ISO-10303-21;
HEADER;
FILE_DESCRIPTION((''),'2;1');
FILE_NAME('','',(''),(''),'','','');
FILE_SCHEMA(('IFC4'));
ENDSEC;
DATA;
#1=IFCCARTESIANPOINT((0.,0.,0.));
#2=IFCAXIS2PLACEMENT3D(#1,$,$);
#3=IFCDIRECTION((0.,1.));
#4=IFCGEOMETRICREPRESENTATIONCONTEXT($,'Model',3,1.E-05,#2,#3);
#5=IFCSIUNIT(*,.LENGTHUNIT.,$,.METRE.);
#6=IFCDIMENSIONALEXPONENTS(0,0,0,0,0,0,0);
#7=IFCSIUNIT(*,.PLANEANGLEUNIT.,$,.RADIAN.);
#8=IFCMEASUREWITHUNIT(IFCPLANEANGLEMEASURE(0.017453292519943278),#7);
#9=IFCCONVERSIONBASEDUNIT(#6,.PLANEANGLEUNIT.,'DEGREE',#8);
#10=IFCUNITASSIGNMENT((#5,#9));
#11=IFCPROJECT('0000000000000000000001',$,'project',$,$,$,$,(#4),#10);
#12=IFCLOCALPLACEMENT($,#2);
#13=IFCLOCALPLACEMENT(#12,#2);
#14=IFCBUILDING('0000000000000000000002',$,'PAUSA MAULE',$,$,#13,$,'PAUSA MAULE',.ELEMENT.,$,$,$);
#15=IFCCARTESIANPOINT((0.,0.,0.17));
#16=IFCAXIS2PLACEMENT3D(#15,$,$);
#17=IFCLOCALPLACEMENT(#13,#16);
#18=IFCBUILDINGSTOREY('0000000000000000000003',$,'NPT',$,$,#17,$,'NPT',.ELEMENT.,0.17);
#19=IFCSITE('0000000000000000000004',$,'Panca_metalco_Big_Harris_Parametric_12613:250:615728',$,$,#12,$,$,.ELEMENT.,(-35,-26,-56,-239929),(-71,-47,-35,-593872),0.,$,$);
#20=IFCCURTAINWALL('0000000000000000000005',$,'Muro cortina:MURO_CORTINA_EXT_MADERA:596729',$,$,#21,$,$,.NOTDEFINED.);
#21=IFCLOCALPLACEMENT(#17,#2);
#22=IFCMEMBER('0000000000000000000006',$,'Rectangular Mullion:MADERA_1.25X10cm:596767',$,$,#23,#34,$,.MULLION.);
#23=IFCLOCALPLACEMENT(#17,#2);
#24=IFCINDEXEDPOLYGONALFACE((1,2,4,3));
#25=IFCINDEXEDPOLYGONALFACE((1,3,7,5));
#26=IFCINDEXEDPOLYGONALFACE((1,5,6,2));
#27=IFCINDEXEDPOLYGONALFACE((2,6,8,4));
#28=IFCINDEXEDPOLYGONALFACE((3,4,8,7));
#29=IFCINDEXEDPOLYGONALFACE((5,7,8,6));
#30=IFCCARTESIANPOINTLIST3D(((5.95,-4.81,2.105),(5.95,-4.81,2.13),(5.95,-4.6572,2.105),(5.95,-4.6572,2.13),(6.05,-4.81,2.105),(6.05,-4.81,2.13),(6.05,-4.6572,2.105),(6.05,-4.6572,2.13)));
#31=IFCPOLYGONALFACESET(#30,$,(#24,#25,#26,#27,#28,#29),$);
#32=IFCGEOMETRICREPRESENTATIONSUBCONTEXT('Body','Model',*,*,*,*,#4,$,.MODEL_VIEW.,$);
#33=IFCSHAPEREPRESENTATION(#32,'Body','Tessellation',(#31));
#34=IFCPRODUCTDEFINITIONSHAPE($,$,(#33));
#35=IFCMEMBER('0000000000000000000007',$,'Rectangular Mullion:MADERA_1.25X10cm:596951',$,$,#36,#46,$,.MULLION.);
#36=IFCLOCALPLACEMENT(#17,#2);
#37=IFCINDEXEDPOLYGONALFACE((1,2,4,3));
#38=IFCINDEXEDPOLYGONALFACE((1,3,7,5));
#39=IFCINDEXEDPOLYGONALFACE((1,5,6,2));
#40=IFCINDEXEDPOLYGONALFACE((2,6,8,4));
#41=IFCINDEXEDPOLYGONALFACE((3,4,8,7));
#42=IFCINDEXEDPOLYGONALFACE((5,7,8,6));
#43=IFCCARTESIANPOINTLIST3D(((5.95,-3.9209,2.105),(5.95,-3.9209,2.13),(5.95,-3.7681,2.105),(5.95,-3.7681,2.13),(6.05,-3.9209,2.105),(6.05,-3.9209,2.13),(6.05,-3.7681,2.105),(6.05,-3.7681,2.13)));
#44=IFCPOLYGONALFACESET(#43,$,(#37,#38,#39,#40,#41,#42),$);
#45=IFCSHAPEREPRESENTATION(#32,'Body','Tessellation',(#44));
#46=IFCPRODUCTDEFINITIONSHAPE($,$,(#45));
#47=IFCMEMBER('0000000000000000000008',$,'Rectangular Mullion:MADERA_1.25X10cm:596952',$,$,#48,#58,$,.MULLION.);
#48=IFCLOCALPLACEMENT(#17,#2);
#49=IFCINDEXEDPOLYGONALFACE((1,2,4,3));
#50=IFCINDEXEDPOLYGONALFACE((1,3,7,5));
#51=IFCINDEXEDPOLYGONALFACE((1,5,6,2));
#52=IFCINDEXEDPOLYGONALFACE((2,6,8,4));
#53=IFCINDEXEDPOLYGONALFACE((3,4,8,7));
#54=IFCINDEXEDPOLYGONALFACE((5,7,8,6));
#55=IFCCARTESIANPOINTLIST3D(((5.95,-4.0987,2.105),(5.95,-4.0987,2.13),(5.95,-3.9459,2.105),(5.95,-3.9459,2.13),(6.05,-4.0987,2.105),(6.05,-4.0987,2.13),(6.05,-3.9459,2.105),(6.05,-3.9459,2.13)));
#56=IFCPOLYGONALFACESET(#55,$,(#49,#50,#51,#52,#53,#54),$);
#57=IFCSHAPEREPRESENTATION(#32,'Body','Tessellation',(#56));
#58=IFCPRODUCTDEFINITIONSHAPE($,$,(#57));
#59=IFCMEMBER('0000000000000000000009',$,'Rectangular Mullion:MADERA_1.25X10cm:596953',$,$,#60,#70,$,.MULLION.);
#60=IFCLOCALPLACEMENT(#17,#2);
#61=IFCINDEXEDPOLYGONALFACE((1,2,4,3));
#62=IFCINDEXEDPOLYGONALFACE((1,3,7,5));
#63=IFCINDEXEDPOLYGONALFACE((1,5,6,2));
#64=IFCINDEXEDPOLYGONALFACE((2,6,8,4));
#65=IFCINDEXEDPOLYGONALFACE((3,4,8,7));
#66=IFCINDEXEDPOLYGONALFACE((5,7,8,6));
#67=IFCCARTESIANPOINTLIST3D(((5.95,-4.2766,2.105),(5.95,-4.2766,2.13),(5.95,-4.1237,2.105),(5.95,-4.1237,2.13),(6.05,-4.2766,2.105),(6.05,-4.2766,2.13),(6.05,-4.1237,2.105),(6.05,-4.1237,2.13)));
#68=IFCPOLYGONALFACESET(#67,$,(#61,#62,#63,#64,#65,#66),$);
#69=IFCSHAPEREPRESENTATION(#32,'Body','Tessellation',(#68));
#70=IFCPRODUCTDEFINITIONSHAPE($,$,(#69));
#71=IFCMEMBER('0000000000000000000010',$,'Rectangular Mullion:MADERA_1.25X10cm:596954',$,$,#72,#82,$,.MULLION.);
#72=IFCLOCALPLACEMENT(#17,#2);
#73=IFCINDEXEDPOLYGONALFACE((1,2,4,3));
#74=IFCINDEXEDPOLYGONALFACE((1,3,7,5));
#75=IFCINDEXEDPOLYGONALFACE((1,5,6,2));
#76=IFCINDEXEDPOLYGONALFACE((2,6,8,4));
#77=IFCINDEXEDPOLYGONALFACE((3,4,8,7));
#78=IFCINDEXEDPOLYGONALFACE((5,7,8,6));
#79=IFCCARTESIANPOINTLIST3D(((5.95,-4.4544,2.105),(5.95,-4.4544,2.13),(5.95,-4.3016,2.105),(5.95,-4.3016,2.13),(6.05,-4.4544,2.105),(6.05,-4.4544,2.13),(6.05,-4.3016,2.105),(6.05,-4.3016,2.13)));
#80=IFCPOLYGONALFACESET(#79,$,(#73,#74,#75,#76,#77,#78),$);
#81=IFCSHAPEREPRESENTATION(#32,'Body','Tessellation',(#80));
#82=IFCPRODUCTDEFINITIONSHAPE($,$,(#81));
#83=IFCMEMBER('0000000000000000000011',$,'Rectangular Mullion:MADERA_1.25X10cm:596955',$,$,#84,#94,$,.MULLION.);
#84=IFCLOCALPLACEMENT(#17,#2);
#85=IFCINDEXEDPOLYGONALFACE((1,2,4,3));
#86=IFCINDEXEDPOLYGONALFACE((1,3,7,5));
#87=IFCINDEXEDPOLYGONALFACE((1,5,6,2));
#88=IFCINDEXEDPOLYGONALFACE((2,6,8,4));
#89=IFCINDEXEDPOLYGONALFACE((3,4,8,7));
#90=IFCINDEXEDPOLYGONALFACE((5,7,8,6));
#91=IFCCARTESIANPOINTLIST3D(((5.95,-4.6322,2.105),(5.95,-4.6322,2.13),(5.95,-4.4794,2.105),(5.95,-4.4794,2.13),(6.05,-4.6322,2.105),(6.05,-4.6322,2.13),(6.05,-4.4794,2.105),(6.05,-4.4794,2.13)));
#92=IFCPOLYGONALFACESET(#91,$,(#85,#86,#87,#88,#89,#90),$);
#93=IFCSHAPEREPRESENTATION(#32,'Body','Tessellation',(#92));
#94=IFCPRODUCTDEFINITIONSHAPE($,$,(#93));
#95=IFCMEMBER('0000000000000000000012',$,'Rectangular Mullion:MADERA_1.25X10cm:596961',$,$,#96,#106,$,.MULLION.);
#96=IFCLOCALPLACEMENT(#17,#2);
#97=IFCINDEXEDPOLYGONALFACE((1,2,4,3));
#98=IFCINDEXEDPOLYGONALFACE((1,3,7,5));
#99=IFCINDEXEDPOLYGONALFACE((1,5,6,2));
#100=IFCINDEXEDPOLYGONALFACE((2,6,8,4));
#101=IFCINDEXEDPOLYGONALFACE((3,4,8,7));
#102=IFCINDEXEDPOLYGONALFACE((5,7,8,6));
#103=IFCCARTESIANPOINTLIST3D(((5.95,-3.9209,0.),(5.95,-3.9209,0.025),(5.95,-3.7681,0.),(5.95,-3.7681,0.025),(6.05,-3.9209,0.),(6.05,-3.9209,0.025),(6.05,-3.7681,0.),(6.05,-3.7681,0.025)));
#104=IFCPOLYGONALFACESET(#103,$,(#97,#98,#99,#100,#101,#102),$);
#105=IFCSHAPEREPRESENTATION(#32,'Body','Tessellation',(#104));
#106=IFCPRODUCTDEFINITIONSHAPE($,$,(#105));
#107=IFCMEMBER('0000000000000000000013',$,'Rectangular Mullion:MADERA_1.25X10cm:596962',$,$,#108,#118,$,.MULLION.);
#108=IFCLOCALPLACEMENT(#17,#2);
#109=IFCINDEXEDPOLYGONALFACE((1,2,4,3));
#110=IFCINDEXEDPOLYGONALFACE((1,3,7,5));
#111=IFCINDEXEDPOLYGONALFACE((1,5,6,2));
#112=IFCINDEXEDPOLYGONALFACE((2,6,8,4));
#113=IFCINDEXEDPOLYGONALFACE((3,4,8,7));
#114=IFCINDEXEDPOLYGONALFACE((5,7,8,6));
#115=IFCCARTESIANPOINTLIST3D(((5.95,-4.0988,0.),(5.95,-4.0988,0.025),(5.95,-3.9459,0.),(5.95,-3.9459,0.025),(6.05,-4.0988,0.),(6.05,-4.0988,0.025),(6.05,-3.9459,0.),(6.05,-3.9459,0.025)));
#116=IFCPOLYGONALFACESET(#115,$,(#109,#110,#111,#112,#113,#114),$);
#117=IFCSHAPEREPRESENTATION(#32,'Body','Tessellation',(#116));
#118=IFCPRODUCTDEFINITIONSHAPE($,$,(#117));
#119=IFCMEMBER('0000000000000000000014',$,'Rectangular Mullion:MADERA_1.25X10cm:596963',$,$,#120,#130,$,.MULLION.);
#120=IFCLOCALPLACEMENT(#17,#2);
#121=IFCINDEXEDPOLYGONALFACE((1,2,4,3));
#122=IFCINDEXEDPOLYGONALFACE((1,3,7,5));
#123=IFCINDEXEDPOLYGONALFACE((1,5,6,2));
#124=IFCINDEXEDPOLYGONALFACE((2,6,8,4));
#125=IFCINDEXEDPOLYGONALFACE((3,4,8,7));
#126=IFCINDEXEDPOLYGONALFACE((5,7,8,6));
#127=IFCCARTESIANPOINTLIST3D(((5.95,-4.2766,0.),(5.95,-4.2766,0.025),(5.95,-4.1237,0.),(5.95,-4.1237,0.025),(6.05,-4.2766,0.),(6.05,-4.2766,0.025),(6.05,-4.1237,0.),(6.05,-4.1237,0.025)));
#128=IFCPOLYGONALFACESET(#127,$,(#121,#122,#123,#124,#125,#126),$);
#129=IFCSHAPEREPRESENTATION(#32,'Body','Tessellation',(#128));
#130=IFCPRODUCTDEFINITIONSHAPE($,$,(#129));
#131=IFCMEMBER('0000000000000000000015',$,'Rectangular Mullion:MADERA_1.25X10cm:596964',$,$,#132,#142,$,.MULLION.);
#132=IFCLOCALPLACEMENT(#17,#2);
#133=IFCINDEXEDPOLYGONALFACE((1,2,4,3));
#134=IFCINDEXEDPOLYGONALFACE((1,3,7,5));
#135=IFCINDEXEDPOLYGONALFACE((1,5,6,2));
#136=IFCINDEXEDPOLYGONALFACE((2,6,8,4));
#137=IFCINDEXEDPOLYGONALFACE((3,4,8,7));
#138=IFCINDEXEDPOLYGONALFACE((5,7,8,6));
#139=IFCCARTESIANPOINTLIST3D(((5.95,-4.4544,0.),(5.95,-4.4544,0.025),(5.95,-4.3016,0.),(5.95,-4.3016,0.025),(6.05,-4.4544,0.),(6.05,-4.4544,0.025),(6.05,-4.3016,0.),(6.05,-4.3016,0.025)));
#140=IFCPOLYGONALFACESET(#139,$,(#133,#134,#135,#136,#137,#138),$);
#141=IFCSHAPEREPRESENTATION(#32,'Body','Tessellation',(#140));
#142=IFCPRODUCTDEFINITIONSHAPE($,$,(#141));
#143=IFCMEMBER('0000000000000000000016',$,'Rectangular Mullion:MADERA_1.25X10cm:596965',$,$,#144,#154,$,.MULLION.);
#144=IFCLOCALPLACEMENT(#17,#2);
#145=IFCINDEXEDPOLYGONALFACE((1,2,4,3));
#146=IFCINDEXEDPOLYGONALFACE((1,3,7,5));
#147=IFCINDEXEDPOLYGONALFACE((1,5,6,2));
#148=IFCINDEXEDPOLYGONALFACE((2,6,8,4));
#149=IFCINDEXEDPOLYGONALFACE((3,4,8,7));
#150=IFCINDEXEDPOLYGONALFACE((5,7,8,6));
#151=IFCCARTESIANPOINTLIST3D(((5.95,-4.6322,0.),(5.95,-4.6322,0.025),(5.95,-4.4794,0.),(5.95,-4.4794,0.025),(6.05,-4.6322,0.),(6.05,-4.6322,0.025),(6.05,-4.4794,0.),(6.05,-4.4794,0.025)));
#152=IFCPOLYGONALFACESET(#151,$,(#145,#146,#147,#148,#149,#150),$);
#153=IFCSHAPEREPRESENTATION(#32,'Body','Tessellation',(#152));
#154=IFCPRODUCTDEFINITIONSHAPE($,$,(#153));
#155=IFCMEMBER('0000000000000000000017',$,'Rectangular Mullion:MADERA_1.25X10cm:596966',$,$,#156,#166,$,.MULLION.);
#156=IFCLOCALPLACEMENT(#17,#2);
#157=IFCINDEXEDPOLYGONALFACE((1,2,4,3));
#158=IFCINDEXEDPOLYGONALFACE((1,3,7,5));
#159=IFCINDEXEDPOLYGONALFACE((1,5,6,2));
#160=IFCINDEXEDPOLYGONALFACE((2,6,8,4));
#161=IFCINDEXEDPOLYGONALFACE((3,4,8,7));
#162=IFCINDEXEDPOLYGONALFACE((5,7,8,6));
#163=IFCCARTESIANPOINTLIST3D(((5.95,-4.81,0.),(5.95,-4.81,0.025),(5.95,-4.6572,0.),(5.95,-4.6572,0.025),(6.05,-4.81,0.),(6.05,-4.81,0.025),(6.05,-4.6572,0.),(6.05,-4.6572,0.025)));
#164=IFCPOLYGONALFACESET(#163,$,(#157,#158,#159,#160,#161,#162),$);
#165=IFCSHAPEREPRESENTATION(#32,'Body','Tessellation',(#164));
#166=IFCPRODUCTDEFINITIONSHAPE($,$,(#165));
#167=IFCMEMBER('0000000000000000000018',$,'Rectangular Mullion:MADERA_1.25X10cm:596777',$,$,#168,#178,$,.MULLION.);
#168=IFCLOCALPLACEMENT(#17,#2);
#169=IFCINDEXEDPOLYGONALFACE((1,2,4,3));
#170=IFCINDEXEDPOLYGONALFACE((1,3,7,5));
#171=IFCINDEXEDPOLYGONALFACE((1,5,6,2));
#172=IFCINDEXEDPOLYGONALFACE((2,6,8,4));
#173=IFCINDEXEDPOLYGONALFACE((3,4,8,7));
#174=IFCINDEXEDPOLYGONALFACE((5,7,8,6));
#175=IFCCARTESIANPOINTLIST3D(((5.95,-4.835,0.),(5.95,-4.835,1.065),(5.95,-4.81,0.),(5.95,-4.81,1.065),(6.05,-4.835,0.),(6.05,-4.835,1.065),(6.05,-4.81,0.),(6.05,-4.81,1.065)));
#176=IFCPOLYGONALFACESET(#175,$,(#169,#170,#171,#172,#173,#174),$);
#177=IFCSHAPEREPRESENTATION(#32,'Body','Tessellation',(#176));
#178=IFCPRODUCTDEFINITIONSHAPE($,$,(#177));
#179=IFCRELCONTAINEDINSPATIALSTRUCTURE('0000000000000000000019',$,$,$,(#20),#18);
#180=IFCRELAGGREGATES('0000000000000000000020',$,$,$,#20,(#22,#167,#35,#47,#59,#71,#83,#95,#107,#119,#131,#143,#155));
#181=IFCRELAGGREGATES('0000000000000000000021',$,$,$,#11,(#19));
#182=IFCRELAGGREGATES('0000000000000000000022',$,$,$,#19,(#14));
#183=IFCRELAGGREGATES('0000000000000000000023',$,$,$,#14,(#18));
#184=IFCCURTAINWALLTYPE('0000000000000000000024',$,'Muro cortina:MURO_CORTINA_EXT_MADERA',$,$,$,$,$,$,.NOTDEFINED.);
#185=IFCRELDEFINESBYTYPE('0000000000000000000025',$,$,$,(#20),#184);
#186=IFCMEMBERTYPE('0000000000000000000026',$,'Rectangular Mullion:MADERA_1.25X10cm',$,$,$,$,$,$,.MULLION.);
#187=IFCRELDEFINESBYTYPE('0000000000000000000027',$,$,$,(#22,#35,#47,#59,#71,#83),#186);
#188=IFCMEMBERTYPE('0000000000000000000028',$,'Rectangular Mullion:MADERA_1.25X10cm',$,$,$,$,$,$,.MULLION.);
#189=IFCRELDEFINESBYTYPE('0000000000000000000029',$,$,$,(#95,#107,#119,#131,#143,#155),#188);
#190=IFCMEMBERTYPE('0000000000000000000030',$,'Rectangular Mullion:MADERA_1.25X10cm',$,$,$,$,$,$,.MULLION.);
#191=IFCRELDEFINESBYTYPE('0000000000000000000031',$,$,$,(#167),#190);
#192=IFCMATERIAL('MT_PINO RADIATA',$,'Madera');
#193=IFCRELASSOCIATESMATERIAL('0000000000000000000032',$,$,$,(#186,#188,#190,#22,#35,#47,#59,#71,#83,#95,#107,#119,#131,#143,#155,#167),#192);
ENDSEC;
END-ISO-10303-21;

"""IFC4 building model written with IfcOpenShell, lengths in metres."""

from ifc_helpers import new_model, entity, si_unit, converted_unit, direction, frame, frame_2d, origin, origin_2d_with_axis, place, context, subcontext, project, spatial, rectangle, extrude, source, transform, mapped, material, material_profile, profile_set, profile_usage, type_object, type_shapes, element, aggregate, save


model = new_model("IFC4")

# Units and contexts
model_context = context("Model", 3, precision=1e-05, world=origin(), true_north=direction((0.0, 1.0)))
body_context = subcontext(model_context, "Body", "Model", "MODEL_VIEW")
ifc_project = project(units=[si_unit("LENGTHUNIT", "METRE"), converted_unit("PLANEANGLEUNIT", "DEGREE", entity("IfcPlaneAngleMeasure", 0.017453292519943278), si_unit("PLANEANGLEUNIT", "RADIAN"), dimensions=[0, 0, 0, 0, 0, 0, 0])], contexts=[model_context])

# Site, building, storey
site_placement = place(None, origin())
site = spatial("IfcSite", under=ifc_project, at=site_placement, Name="Panca_metalco_Big_Harris_Parametric_12613:250:615728", CompositionType="ELEMENT", RefLatitude=(-35, -26, -56, -239929), RefLongitude=(-71, -47, -35, -593872), RefElevation=0.0)
building_placement = place(site_placement, origin())
building = spatial("IfcBuilding", under=site, at=building_placement, Name="PAUSA MAULE", LongName="PAUSA MAULE", CompositionType="ELEMENT")
storey_placement = place(building_placement, frame((0.0, 0.0, 0.17)))
storey = spatial("IfcBuildingStorey", under=building, at=storey_placement, Name="NPT", LongName="NPT", CompositionType="ELEMENT", Elevation=0.17)

# Curtain wall, members
curtain_wall_type = type_object("IfcCurtainWallType", Name="Muro cortina:MURO_CORTINA_EXT_MADERA", PredefinedType="NOTDEFINED")
curtain_wall_placement = place(storey_placement, frame((0.0, 0.0, -0.17)))
curtain_wall = element("IfcCurtainWall", 1, at=curtain_wall_placement, inside=storey, type_object=curtain_wall_type, Name="Muro cortina:MURO_CORTINA_EXT_MADERA:596729", PredefinedType="NOTDEFINED")
ifc_material = material(Name="MT_PINO RADIATA", Category="Madera")
ifc_material_profile = material_profile(ifc_material, rectangle(XDim=0.025, YDim=0.1, at=frame_2d((0.0, 0.0), x_axis=(1.0, 0.0))), Name="MADERA_1.25X10cm")
ifc_profile_set = profile_set([ifc_material_profile], Name="MADERA_1.25X10cm")
ifc_profile_usage = profile_usage(ifc_profile_set)
member_type_1 = type_object("IfcMemberType", Name="Rectangular Mullion:MADERA_1.25X10cm", PredefinedType="MULLION", material=ifc_profile_set)
shared_shape_1 = source(origin(), body_context, "Body", "SweptSolid", [
    extrude(rectangle(XDim=0.025, YDim=0.1, at=frame_2d((0.0, 0.0), x_axis=(1.0, 0.0))), frame((-0.0125, 0.0, -0.1528), z_axis=(0.0, 0.0, 1.0), x_axis=(-1.0, 0.0, 0.0)), (0.0, 0.0, 1.0), 0.1528),
])
type_shapes(member_type_1, [shared_shape_1])
member_1_placement = place(curtain_wall_placement, frame((6.0, -4.81, 2.3), z_axis=(0.0, -1.0, 0.0), x_axis=(0.0, 0.0, 1.0)))
member_1 = element("IfcMember", 2, at=member_1_placement, type_object=member_type_1, material=ifc_profile_usage, Name="Rectangular Mullion:MADERA_1.25X10cm:596767", PredefinedType="MULLION", context=body_context, shape_type="MappedRepresentation", body=[
    mapped(shared_shape_1, transform((0.0, 0.0, 0.0), scale=1.0)),
])
member_2_placement = place(curtain_wall_placement, frame((6.0, -3.9209, 2.3), z_axis=(0.0, -1.0, 0.0), x_axis=(0.0, 0.0, 1.0)))
member_2 = element("IfcMember", 3, at=member_2_placement, type_object=member_type_1, material=ifc_profile_usage, Name="Rectangular Mullion:MADERA_1.25X10cm:596951", PredefinedType="MULLION", context=body_context, shape_type="MappedRepresentation", body=[
    mapped(shared_shape_1, transform((0.0, 0.0, 0.0), scale=1.0)),
])
member_3_placement = place(curtain_wall_placement, frame((6.0, -4.0987, 2.3), z_axis=(0.0, -1.0, 0.0), x_axis=(0.0, 0.0, 1.0)))
member_3 = element("IfcMember", 4, at=member_3_placement, type_object=member_type_1, material=ifc_profile_usage, Name="Rectangular Mullion:MADERA_1.25X10cm:596952", PredefinedType="MULLION", context=body_context, shape_type="MappedRepresentation", body=[
    mapped(shared_shape_1, transform((0.0, 0.0, 0.0), scale=1.0)),
])
member_4_placement = place(curtain_wall_placement, frame((6.0, -4.2766, 2.3), z_axis=(0.0, -1.0, 0.0), x_axis=(0.0, 0.0, 1.0)))
member_4 = element("IfcMember", 5, at=member_4_placement, type_object=member_type_1, material=ifc_profile_usage, Name="Rectangular Mullion:MADERA_1.25X10cm:596953", PredefinedType="MULLION", context=body_context, shape_type="MappedRepresentation", body=[
    mapped(shared_shape_1, transform((0.0, 0.0, 0.0), scale=1.0)),
])
member_5_placement = place(curtain_wall_placement, frame((6.0, -4.4544, 2.3), z_axis=(0.0, -1.0, 0.0), x_axis=(0.0, 0.0, 1.0)))
member_5 = element("IfcMember", 6, at=member_5_placement, type_object=member_type_1, material=ifc_profile_usage, Name="Rectangular Mullion:MADERA_1.25X10cm:596954", PredefinedType="MULLION", context=body_context, shape_type="MappedRepresentation", body=[
    mapped(shared_shape_1, transform((0.0, 0.0, 0.0), scale=1.0)),
])
member_6_placement = place(curtain_wall_placement, frame((6.0, -4.6322, 2.3), z_axis=(0.0, -1.0, 0.0), x_axis=(0.0, 0.0, 1.0)))
member_6 = element("IfcMember", 7, at=member_6_placement, type_object=member_type_1, material=ifc_profile_usage, Name="Rectangular Mullion:MADERA_1.25X10cm:596955", PredefinedType="MULLION", context=body_context, shape_type="MappedRepresentation", body=[
    mapped(shared_shape_1, transform((0.0, 0.0, 0.0), scale=1.0)),
])
member_type_2 = type_object("IfcMemberType", Name="Rectangular Mullion:MADERA_1.25X10cm", PredefinedType="MULLION", material=ifc_profile_set)
shared_shape_2 = source(origin(), body_context, "Body", "SweptSolid", [
    extrude(rectangle(XDim=0.025, YDim=0.1, at=frame_2d((0.0, 0.0), x_axis=(1.0, 0.0))), frame((-0.0125, 0.0, -0.1528), z_axis=(0.0, 0.0, 1.0), x_axis=(-1.0, 0.0, 0.0)), (0.0, 0.0, 1.0), 0.1528),
])
type_shapes(member_type_2, [shared_shape_2])
member_7_placement = place(curtain_wall_placement, frame((6.0, -3.7681, 0.17), z_axis=(0.0, 1.0, 0.0), x_axis=(0.0, 0.0, -1.0)))
member_7 = element("IfcMember", 8, at=member_7_placement, type_object=member_type_2, material=ifc_profile_usage, Name="Rectangular Mullion:MADERA_1.25X10cm:596961", PredefinedType="MULLION", context=body_context, shape_type="MappedRepresentation", body=[
    mapped(shared_shape_2, transform((0.0, 0.0, 0.0), scale=1.0)),
])
member_8_placement = place(curtain_wall_placement, frame((6.0, -3.9459, 0.17), z_axis=(0.0, 1.0, 0.0), x_axis=(0.0, 0.0, -1.0)))
member_8 = element("IfcMember", 9, at=member_8_placement, type_object=member_type_2, material=ifc_profile_usage, Name="Rectangular Mullion:MADERA_1.25X10cm:596962", PredefinedType="MULLION", context=body_context, shape_type="MappedRepresentation", body=[
    mapped(shared_shape_2, transform((0.0, 0.0, 0.0), scale=1.0)),
])
member_9_placement = place(curtain_wall_placement, frame((6.0, -4.1237, 0.17), z_axis=(0.0, 1.0, 0.0), x_axis=(0.0, 0.0, -1.0)))
member_9 = element("IfcMember", 10, at=member_9_placement, type_object=member_type_2, material=ifc_profile_usage, Name="Rectangular Mullion:MADERA_1.25X10cm:596963", PredefinedType="MULLION", context=body_context, shape_type="MappedRepresentation", body=[
    mapped(shared_shape_2, transform((0.0, 0.0, 0.0), scale=1.0)),
])
member_10_placement = place(curtain_wall_placement, frame((6.0, -4.3016, 0.17), z_axis=(0.0, 1.0, 0.0), x_axis=(0.0, 0.0, -1.0)))
member_10 = element("IfcMember", 11, at=member_10_placement, type_object=member_type_2, material=ifc_profile_usage, Name="Rectangular Mullion:MADERA_1.25X10cm:596964", PredefinedType="MULLION", context=body_context, shape_type="MappedRepresentation", body=[
    mapped(shared_shape_2, transform((0.0, 0.0, 0.0), scale=1.0)),
])
member_11_placement = place(curtain_wall_placement, frame((6.0, -4.4794, 0.17), z_axis=(0.0, 1.0, 0.0), x_axis=(0.0, 0.0, -1.0)))
member_11 = element("IfcMember", 12, at=member_11_placement, type_object=member_type_2, material=ifc_profile_usage, Name="Rectangular Mullion:MADERA_1.25X10cm:596965", PredefinedType="MULLION", context=body_context, shape_type="MappedRepresentation", body=[
    mapped(shared_shape_2, transform((0.0, 0.0, 0.0), scale=1.0)),
])
member_12_placement = place(curtain_wall_placement, frame((6.0, -4.6572, 0.17), z_axis=(0.0, 1.0, 0.0), x_axis=(0.0, 0.0, -1.0)))
member_12 = element("IfcMember", 13, at=member_12_placement, type_object=member_type_2, material=ifc_profile_usage, Name="Rectangular Mullion:MADERA_1.25X10cm:596966", PredefinedType="MULLION", context=body_context, shape_type="MappedRepresentation", body=[
    mapped(shared_shape_2, transform((0.0, 0.0, 0.0), scale=1.0)),
])
member_type_3 = type_object("IfcMemberType", Name="Rectangular Mullion:MADERA_1.25X10cm", PredefinedType="MULLION", material=ifc_profile_set)
shared_shape_3 = source(origin(), body_context, "Body", "SweptSolid", [
    extrude(rectangle(XDim=0.025, YDim=0.1, at=origin_2d_with_axis()), frame((-0.0125, 0.0, -1.065), z_axis=(0.0, 0.0, 1.0), x_axis=(-1.0, 0.0, 0.0)), (0.0, 0.0, 1.0), 1.065),
])
type_shapes(member_type_3, [shared_shape_3])
member_13_placement = place(curtain_wall_placement, frame((6.0, -4.835, 0.17), z_axis=(0.0, 0.0, -1.0), x_axis=(0.0, -1.0, 0.0)))
member_13 = element("IfcMember", 14, at=member_13_placement, type_object=member_type_3, material=ifc_profile_usage, Name="Rectangular Mullion:MADERA_1.25X10cm:596777", PredefinedType="MULLION", context=body_context, shape_type="MappedRepresentation", body=[
    mapped(shared_shape_3, transform((0.0, 0.0, 0.0), scale=1.0)),
])
aggregate(curtain_wall, [member_1, member_13, member_2, member_3, member_4, member_5, member_6, member_7, member_8, member_9, member_10, member_11, member_12])

save(model, "model.ifc")
